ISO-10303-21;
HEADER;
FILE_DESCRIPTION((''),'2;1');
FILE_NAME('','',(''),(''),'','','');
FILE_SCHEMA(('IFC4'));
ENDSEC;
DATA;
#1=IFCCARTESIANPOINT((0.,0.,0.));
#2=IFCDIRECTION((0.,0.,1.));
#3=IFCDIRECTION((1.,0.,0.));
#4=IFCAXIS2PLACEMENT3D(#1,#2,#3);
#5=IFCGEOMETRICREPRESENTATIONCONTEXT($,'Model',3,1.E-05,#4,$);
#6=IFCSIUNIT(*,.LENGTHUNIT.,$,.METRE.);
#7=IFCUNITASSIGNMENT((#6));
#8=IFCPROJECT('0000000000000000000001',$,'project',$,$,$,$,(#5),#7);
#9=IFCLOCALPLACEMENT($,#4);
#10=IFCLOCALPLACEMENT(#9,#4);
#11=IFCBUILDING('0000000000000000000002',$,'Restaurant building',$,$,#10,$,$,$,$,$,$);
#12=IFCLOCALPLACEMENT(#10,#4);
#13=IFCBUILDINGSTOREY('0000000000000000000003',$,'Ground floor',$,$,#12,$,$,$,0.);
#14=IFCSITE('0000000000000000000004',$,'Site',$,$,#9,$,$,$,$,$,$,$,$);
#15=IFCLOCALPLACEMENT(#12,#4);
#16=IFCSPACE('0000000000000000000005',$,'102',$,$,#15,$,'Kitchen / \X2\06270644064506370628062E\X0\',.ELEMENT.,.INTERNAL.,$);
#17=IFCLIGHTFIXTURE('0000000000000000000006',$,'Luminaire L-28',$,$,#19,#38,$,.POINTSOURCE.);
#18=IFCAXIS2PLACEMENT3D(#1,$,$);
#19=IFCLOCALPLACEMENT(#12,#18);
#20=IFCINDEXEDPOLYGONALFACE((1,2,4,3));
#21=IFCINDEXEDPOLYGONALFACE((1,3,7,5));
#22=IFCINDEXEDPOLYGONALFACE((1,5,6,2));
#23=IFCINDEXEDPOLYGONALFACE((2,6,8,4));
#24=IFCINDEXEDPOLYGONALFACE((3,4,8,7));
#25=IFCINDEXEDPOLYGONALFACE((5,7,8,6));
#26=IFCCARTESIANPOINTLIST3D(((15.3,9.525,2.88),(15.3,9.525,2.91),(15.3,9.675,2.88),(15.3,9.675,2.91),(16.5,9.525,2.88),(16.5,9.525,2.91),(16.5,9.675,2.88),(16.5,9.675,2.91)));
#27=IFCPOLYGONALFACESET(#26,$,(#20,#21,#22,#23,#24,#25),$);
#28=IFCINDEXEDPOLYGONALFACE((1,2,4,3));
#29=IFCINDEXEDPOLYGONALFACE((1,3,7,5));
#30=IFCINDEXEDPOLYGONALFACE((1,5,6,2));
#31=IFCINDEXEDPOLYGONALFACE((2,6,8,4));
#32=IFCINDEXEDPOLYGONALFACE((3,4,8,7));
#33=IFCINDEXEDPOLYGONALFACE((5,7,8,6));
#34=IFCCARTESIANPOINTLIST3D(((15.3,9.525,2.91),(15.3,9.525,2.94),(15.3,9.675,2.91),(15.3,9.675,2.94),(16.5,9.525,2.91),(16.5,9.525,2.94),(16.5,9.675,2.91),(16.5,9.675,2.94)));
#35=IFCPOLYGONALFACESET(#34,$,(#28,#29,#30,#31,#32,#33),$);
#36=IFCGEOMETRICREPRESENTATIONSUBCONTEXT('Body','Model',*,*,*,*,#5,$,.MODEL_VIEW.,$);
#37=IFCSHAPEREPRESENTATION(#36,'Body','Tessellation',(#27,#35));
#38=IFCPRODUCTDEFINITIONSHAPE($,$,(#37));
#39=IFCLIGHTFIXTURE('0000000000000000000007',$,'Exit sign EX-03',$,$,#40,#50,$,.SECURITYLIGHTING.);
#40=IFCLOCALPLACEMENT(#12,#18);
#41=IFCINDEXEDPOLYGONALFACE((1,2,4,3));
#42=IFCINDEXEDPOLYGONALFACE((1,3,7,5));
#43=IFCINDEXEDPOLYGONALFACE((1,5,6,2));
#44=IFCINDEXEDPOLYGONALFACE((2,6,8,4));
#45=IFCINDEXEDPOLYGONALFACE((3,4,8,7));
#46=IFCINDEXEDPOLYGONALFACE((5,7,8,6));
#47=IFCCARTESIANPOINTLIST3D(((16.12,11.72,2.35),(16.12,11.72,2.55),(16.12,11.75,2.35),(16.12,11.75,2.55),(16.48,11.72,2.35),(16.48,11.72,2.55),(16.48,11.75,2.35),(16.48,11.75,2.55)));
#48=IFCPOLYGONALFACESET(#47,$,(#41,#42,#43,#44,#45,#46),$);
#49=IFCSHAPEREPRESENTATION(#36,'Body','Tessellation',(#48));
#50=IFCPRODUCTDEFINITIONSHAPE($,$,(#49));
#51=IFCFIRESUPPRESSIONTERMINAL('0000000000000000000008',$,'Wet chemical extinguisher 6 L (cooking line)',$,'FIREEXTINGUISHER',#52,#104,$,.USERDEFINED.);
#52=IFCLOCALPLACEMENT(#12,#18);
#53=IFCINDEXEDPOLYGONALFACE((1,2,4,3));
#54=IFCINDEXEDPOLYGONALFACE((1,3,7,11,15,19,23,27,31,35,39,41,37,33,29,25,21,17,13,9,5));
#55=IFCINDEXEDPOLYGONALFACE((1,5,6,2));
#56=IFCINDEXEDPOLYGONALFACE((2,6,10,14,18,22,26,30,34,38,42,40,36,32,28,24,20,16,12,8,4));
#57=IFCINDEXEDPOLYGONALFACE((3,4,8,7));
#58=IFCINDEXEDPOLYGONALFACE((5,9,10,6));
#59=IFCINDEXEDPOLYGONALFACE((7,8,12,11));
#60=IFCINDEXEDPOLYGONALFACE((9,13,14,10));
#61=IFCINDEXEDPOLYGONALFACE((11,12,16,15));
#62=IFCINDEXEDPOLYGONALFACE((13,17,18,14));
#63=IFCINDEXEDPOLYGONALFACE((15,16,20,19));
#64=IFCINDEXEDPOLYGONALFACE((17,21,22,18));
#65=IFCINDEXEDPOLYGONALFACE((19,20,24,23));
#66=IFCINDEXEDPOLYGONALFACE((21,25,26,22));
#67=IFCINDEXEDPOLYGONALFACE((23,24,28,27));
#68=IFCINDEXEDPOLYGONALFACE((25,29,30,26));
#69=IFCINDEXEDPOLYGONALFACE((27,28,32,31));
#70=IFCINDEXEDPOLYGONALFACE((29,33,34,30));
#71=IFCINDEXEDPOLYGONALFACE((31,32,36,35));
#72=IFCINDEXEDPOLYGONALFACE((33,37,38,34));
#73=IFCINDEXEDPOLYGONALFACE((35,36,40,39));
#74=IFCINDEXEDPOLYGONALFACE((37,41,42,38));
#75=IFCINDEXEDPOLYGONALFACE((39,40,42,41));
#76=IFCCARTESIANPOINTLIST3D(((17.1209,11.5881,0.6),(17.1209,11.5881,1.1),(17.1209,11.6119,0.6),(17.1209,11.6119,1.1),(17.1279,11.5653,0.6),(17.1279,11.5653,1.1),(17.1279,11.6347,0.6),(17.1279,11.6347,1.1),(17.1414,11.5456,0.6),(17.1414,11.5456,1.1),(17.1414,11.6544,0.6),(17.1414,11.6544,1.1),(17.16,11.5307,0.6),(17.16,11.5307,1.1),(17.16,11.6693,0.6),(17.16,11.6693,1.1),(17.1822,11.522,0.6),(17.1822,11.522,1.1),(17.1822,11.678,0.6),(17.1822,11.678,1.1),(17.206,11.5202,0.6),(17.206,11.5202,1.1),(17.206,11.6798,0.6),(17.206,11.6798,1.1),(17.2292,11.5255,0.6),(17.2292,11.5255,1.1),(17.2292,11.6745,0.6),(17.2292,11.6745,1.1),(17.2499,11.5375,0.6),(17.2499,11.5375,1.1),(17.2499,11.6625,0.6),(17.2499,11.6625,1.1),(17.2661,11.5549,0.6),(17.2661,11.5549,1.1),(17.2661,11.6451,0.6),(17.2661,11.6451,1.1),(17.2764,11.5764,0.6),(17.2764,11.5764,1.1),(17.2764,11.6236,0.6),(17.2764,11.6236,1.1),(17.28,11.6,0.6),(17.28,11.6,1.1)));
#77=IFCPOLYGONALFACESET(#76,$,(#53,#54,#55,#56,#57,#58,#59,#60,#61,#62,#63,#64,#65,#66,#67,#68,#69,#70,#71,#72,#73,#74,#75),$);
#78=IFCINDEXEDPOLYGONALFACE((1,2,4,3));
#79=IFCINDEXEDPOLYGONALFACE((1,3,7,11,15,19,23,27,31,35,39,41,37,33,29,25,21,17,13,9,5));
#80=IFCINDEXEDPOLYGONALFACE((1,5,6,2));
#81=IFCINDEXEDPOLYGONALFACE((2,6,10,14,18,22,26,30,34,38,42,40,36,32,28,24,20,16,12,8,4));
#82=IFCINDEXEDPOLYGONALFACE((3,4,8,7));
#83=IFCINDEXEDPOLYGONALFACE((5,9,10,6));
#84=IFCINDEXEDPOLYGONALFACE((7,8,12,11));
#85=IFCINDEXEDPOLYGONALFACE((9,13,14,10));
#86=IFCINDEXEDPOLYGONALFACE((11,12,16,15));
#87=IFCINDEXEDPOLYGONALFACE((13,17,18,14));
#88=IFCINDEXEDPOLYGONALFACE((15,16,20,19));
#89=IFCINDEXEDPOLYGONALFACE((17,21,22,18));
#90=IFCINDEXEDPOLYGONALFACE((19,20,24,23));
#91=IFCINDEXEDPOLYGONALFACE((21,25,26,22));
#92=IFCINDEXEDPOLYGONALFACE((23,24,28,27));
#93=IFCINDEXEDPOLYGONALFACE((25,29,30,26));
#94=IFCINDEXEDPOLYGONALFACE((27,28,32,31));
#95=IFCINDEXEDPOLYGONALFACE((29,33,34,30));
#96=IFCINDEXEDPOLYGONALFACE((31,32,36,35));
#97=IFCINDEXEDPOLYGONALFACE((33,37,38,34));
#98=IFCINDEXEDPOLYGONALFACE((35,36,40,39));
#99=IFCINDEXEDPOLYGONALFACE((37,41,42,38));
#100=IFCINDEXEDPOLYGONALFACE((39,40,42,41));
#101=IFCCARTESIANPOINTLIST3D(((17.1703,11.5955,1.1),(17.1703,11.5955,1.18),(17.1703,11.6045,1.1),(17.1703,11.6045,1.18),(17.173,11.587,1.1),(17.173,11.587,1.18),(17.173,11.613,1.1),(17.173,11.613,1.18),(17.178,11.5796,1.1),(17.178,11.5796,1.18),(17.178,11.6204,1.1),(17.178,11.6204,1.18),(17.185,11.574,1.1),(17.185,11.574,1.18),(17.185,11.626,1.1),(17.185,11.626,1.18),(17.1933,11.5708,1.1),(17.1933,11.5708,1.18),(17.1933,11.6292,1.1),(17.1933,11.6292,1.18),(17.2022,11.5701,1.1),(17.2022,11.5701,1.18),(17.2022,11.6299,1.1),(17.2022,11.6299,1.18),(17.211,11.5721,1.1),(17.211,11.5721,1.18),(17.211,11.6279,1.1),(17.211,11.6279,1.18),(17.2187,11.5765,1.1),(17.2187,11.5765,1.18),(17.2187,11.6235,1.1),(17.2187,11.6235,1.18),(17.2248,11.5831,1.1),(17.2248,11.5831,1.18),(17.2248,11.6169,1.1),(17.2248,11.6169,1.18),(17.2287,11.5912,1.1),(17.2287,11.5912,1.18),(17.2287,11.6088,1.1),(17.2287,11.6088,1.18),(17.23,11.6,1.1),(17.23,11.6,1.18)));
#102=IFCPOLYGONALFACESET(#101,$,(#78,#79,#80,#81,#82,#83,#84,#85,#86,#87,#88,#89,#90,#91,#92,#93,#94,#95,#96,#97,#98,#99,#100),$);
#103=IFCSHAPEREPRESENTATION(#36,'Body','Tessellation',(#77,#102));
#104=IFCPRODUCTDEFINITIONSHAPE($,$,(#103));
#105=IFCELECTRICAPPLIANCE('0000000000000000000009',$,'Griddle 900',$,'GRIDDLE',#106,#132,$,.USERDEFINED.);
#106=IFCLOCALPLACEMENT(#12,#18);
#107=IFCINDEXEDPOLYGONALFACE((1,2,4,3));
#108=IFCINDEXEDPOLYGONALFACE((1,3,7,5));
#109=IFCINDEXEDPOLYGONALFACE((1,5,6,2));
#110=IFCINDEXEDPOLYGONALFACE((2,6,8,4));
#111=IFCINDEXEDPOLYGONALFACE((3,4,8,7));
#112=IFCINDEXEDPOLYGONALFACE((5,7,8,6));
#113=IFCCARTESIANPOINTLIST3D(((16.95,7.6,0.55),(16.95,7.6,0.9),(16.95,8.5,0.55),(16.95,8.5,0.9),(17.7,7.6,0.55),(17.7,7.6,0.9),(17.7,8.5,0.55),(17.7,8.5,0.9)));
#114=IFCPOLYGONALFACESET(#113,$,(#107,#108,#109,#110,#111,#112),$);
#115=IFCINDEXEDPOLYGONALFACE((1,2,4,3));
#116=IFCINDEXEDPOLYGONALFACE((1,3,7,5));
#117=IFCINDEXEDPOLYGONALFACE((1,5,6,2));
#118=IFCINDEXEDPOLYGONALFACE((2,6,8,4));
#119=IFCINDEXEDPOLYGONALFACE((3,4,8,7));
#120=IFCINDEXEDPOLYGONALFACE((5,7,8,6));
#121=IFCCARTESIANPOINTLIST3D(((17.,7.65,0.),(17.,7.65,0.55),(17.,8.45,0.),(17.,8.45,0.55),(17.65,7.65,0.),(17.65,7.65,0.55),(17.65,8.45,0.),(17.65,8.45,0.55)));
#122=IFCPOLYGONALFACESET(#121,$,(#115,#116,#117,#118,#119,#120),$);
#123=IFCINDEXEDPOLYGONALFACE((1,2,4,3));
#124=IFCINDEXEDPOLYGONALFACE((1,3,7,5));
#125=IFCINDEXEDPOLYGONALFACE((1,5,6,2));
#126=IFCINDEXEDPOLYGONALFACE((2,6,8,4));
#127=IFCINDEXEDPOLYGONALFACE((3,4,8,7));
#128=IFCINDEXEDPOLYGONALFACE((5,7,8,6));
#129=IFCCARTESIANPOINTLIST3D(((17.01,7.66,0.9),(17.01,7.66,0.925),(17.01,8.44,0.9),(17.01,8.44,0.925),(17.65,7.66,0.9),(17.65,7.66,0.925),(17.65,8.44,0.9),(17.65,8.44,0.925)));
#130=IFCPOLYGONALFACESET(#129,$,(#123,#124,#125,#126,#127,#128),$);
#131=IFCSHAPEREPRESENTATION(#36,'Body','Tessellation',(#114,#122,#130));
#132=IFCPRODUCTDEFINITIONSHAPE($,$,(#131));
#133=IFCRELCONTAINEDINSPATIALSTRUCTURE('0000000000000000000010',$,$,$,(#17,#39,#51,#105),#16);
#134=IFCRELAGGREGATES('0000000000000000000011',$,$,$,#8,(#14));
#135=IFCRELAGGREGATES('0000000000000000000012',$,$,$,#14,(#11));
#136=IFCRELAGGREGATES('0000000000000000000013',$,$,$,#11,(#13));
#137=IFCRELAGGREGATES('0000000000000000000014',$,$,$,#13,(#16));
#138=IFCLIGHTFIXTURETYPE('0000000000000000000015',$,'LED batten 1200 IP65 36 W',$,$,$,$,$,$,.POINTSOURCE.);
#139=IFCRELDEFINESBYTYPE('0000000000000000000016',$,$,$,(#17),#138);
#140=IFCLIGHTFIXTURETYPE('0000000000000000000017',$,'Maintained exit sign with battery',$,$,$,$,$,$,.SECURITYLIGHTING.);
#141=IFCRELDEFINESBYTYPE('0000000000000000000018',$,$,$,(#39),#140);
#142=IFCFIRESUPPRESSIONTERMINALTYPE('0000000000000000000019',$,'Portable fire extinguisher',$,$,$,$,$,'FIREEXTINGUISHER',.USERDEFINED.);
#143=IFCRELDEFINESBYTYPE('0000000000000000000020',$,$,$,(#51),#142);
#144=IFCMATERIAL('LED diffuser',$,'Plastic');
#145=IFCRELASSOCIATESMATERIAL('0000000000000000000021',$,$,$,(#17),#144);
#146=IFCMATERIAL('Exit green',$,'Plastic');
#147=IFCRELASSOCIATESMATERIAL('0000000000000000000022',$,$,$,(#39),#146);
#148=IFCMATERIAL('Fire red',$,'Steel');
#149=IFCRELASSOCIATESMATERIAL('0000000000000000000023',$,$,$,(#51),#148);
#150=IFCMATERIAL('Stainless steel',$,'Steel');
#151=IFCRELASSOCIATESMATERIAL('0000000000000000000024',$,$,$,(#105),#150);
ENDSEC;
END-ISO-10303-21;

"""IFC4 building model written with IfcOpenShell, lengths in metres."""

from ifc_helpers import new_model, si_unit, frame, origin, origin_with_axes, origin_2d, place, context, subcontext, project, spatial, rectangle, circle, extrude, source, transform, mapped, material, type_object, type_shapes, element, save


model = new_model("IFC4")

# Units and contexts
model_context = context("Model", 3, precision=1e-05, world=origin_with_axes())
body_context = subcontext(model_context, "Body", "Model", "MODEL_VIEW")
ifc_project = project(units=[si_unit("LENGTHUNIT", "METRE")], contexts=[model_context])

# Site, building, storey, space
site_placement = place(None, origin_with_axes())
site = spatial("IfcSite", under=ifc_project, at=site_placement, Name="Site")
building_placement = place(site_placement, origin_with_axes())
building = spatial("IfcBuilding", under=site, at=building_placement, Name="Restaurant building")
storey_placement = place(building_placement, origin_with_axes())
storey = spatial("IfcBuildingStorey", under=building, at=storey_placement, Name="Ground floor", Elevation=0.0)
space_placement = place(storey_placement, origin_with_axes())
space = spatial("IfcSpace", under=storey, at=space_placement, Name="102", LongName="Kitchen / المطبخ", CompositionType="ELEMENT", PredefinedType="INTERNAL")

# Light fixtures
ifc_material_1 = material(Name="LED diffuser", Category="Plastic")
light_fixture_type_1 = type_object("IfcLightFixtureType", Name="LED batten 1200 IP65 36 W", PredefinedType="POINTSOURCE")
shared_shape_1 = source(origin(), body_context, "Body", "SweptSolid", [
    extrude(rectangle(XDim=1.2, YDim=0.15, at=origin_2d()), frame((0.0, 0.0, -0.06)), (0.0, 0.0, 1.0), 0.03),
    extrude(rectangle(XDim=1.2, YDim=0.15, at=origin_2d()), frame((0.0, 0.0, -0.03)), (0.0, 0.0, 1.0), 0.03),
])
type_shapes(light_fixture_type_1, [shared_shape_1])
light_fixture_1_placement = place(storey_placement, frame((15.9, 9.6, 2.94)))
element("IfcLightFixture", 1, at=light_fixture_1_placement, inside=space, type_object=light_fixture_type_1, material=ifc_material_1, Name="Luminaire L-28", PredefinedType="POINTSOURCE", context=body_context, shape_type="MappedRepresentation", body=[
    mapped(shared_shape_1, transform((0.0, 0.0, 0.0))),
])
ifc_material_2 = material(Name="Exit green", Category="Plastic")
light_fixture_type_2 = type_object("IfcLightFixtureType", Name="Maintained exit sign with battery", PredefinedType="SECURITYLIGHTING")
shared_shape_2 = source(origin(), body_context, "Body", "SweptSolid", [
    extrude(rectangle(XDim=0.36, YDim=0.03, at=origin_2d()), frame((0.0, 0.015, -0.1)), (0.0, 0.0, 1.0), 0.2),
])
type_shapes(light_fixture_type_2, [shared_shape_2])
light_fixture_2_placement = place(storey_placement, frame((16.3, 11.75, 2.45), z_axis=(0.0, 0.0, 1.0), x_axis=(-1.0, 0.0, 0.0)))
element("IfcLightFixture", 2, at=light_fixture_2_placement, inside=space, type_object=light_fixture_type_2, material=ifc_material_2, Name="Exit sign EX-03", PredefinedType="SECURITYLIGHTING", context=body_context, shape_type="MappedRepresentation", body=[
    mapped(shared_shape_2, transform((0.0, 0.0, 0.0))),
])

# Fire suppression terminal
ifc_material_3 = material(Name="Fire red", Category="Steel")
fire_suppression_terminal_type = type_object("IfcFireSuppressionTerminalType", Name="Portable fire extinguisher", ElementType="FIREEXTINGUISHER", PredefinedType="USERDEFINED")
shared_shape_3 = source(origin(), body_context, "Body", "SweptSolid", [
    extrude(circle(Radius=0.08, at=origin_2d()), origin(), (0.0, 0.0, 1.0), 0.5),
    extrude(circle(Radius=0.03, at=origin_2d()), frame((0.0, 0.0, 0.5)), (0.0, 0.0, 1.0), 0.08),
])
type_shapes(fire_suppression_terminal_type, [shared_shape_3])
fire_suppression_terminal_placement = place(storey_placement, frame((17.2, 11.6, 0.6)))
element("IfcFireSuppressionTerminal", 3, at=fire_suppression_terminal_placement, inside=space, type_object=fire_suppression_terminal_type, material=ifc_material_3, Name="Wet chemical extinguisher 6 L (cooking line)", ObjectType="FIREEXTINGUISHER", PredefinedType="USERDEFINED", context=body_context, shape_type="MappedRepresentation", body=[
    mapped(shared_shape_3, transform((0.0, 0.0, 0.0))),
])

# Electric appliance
ifc_material_4 = material(Name="Stainless steel", Category="Steel")
electric_appliance_1_placement = place(storey_placement, frame((16.95, 7.6, 0.0)))
element("IfcElectricAppliance", 4, at=electric_appliance_1_placement, inside=space, material=ifc_material_4, Name="Griddle 900", ObjectType="GRIDDLE", PredefinedType="USERDEFINED", context=body_context, shape_type="SweptSolid", body=[
    extrude(rectangle(XDim=0.75, YDim=0.9, at=origin_2d()), frame((0.375, 0.45, 0.55)), (0.0, 0.0, 1.0), 0.35),
    extrude(rectangle(XDim=0.65, YDim=0.8, at=origin_2d()), frame((0.375, 0.45, 0.0)), (0.0, 0.0, 1.0), 0.55),
    extrude(rectangle(XDim=0.64, YDim=0.78, at=origin_2d()), frame((0.38, 0.45, 0.9)), (0.0, 0.0, 1.0), 0.025),
])

save(model, "model.ifc")
